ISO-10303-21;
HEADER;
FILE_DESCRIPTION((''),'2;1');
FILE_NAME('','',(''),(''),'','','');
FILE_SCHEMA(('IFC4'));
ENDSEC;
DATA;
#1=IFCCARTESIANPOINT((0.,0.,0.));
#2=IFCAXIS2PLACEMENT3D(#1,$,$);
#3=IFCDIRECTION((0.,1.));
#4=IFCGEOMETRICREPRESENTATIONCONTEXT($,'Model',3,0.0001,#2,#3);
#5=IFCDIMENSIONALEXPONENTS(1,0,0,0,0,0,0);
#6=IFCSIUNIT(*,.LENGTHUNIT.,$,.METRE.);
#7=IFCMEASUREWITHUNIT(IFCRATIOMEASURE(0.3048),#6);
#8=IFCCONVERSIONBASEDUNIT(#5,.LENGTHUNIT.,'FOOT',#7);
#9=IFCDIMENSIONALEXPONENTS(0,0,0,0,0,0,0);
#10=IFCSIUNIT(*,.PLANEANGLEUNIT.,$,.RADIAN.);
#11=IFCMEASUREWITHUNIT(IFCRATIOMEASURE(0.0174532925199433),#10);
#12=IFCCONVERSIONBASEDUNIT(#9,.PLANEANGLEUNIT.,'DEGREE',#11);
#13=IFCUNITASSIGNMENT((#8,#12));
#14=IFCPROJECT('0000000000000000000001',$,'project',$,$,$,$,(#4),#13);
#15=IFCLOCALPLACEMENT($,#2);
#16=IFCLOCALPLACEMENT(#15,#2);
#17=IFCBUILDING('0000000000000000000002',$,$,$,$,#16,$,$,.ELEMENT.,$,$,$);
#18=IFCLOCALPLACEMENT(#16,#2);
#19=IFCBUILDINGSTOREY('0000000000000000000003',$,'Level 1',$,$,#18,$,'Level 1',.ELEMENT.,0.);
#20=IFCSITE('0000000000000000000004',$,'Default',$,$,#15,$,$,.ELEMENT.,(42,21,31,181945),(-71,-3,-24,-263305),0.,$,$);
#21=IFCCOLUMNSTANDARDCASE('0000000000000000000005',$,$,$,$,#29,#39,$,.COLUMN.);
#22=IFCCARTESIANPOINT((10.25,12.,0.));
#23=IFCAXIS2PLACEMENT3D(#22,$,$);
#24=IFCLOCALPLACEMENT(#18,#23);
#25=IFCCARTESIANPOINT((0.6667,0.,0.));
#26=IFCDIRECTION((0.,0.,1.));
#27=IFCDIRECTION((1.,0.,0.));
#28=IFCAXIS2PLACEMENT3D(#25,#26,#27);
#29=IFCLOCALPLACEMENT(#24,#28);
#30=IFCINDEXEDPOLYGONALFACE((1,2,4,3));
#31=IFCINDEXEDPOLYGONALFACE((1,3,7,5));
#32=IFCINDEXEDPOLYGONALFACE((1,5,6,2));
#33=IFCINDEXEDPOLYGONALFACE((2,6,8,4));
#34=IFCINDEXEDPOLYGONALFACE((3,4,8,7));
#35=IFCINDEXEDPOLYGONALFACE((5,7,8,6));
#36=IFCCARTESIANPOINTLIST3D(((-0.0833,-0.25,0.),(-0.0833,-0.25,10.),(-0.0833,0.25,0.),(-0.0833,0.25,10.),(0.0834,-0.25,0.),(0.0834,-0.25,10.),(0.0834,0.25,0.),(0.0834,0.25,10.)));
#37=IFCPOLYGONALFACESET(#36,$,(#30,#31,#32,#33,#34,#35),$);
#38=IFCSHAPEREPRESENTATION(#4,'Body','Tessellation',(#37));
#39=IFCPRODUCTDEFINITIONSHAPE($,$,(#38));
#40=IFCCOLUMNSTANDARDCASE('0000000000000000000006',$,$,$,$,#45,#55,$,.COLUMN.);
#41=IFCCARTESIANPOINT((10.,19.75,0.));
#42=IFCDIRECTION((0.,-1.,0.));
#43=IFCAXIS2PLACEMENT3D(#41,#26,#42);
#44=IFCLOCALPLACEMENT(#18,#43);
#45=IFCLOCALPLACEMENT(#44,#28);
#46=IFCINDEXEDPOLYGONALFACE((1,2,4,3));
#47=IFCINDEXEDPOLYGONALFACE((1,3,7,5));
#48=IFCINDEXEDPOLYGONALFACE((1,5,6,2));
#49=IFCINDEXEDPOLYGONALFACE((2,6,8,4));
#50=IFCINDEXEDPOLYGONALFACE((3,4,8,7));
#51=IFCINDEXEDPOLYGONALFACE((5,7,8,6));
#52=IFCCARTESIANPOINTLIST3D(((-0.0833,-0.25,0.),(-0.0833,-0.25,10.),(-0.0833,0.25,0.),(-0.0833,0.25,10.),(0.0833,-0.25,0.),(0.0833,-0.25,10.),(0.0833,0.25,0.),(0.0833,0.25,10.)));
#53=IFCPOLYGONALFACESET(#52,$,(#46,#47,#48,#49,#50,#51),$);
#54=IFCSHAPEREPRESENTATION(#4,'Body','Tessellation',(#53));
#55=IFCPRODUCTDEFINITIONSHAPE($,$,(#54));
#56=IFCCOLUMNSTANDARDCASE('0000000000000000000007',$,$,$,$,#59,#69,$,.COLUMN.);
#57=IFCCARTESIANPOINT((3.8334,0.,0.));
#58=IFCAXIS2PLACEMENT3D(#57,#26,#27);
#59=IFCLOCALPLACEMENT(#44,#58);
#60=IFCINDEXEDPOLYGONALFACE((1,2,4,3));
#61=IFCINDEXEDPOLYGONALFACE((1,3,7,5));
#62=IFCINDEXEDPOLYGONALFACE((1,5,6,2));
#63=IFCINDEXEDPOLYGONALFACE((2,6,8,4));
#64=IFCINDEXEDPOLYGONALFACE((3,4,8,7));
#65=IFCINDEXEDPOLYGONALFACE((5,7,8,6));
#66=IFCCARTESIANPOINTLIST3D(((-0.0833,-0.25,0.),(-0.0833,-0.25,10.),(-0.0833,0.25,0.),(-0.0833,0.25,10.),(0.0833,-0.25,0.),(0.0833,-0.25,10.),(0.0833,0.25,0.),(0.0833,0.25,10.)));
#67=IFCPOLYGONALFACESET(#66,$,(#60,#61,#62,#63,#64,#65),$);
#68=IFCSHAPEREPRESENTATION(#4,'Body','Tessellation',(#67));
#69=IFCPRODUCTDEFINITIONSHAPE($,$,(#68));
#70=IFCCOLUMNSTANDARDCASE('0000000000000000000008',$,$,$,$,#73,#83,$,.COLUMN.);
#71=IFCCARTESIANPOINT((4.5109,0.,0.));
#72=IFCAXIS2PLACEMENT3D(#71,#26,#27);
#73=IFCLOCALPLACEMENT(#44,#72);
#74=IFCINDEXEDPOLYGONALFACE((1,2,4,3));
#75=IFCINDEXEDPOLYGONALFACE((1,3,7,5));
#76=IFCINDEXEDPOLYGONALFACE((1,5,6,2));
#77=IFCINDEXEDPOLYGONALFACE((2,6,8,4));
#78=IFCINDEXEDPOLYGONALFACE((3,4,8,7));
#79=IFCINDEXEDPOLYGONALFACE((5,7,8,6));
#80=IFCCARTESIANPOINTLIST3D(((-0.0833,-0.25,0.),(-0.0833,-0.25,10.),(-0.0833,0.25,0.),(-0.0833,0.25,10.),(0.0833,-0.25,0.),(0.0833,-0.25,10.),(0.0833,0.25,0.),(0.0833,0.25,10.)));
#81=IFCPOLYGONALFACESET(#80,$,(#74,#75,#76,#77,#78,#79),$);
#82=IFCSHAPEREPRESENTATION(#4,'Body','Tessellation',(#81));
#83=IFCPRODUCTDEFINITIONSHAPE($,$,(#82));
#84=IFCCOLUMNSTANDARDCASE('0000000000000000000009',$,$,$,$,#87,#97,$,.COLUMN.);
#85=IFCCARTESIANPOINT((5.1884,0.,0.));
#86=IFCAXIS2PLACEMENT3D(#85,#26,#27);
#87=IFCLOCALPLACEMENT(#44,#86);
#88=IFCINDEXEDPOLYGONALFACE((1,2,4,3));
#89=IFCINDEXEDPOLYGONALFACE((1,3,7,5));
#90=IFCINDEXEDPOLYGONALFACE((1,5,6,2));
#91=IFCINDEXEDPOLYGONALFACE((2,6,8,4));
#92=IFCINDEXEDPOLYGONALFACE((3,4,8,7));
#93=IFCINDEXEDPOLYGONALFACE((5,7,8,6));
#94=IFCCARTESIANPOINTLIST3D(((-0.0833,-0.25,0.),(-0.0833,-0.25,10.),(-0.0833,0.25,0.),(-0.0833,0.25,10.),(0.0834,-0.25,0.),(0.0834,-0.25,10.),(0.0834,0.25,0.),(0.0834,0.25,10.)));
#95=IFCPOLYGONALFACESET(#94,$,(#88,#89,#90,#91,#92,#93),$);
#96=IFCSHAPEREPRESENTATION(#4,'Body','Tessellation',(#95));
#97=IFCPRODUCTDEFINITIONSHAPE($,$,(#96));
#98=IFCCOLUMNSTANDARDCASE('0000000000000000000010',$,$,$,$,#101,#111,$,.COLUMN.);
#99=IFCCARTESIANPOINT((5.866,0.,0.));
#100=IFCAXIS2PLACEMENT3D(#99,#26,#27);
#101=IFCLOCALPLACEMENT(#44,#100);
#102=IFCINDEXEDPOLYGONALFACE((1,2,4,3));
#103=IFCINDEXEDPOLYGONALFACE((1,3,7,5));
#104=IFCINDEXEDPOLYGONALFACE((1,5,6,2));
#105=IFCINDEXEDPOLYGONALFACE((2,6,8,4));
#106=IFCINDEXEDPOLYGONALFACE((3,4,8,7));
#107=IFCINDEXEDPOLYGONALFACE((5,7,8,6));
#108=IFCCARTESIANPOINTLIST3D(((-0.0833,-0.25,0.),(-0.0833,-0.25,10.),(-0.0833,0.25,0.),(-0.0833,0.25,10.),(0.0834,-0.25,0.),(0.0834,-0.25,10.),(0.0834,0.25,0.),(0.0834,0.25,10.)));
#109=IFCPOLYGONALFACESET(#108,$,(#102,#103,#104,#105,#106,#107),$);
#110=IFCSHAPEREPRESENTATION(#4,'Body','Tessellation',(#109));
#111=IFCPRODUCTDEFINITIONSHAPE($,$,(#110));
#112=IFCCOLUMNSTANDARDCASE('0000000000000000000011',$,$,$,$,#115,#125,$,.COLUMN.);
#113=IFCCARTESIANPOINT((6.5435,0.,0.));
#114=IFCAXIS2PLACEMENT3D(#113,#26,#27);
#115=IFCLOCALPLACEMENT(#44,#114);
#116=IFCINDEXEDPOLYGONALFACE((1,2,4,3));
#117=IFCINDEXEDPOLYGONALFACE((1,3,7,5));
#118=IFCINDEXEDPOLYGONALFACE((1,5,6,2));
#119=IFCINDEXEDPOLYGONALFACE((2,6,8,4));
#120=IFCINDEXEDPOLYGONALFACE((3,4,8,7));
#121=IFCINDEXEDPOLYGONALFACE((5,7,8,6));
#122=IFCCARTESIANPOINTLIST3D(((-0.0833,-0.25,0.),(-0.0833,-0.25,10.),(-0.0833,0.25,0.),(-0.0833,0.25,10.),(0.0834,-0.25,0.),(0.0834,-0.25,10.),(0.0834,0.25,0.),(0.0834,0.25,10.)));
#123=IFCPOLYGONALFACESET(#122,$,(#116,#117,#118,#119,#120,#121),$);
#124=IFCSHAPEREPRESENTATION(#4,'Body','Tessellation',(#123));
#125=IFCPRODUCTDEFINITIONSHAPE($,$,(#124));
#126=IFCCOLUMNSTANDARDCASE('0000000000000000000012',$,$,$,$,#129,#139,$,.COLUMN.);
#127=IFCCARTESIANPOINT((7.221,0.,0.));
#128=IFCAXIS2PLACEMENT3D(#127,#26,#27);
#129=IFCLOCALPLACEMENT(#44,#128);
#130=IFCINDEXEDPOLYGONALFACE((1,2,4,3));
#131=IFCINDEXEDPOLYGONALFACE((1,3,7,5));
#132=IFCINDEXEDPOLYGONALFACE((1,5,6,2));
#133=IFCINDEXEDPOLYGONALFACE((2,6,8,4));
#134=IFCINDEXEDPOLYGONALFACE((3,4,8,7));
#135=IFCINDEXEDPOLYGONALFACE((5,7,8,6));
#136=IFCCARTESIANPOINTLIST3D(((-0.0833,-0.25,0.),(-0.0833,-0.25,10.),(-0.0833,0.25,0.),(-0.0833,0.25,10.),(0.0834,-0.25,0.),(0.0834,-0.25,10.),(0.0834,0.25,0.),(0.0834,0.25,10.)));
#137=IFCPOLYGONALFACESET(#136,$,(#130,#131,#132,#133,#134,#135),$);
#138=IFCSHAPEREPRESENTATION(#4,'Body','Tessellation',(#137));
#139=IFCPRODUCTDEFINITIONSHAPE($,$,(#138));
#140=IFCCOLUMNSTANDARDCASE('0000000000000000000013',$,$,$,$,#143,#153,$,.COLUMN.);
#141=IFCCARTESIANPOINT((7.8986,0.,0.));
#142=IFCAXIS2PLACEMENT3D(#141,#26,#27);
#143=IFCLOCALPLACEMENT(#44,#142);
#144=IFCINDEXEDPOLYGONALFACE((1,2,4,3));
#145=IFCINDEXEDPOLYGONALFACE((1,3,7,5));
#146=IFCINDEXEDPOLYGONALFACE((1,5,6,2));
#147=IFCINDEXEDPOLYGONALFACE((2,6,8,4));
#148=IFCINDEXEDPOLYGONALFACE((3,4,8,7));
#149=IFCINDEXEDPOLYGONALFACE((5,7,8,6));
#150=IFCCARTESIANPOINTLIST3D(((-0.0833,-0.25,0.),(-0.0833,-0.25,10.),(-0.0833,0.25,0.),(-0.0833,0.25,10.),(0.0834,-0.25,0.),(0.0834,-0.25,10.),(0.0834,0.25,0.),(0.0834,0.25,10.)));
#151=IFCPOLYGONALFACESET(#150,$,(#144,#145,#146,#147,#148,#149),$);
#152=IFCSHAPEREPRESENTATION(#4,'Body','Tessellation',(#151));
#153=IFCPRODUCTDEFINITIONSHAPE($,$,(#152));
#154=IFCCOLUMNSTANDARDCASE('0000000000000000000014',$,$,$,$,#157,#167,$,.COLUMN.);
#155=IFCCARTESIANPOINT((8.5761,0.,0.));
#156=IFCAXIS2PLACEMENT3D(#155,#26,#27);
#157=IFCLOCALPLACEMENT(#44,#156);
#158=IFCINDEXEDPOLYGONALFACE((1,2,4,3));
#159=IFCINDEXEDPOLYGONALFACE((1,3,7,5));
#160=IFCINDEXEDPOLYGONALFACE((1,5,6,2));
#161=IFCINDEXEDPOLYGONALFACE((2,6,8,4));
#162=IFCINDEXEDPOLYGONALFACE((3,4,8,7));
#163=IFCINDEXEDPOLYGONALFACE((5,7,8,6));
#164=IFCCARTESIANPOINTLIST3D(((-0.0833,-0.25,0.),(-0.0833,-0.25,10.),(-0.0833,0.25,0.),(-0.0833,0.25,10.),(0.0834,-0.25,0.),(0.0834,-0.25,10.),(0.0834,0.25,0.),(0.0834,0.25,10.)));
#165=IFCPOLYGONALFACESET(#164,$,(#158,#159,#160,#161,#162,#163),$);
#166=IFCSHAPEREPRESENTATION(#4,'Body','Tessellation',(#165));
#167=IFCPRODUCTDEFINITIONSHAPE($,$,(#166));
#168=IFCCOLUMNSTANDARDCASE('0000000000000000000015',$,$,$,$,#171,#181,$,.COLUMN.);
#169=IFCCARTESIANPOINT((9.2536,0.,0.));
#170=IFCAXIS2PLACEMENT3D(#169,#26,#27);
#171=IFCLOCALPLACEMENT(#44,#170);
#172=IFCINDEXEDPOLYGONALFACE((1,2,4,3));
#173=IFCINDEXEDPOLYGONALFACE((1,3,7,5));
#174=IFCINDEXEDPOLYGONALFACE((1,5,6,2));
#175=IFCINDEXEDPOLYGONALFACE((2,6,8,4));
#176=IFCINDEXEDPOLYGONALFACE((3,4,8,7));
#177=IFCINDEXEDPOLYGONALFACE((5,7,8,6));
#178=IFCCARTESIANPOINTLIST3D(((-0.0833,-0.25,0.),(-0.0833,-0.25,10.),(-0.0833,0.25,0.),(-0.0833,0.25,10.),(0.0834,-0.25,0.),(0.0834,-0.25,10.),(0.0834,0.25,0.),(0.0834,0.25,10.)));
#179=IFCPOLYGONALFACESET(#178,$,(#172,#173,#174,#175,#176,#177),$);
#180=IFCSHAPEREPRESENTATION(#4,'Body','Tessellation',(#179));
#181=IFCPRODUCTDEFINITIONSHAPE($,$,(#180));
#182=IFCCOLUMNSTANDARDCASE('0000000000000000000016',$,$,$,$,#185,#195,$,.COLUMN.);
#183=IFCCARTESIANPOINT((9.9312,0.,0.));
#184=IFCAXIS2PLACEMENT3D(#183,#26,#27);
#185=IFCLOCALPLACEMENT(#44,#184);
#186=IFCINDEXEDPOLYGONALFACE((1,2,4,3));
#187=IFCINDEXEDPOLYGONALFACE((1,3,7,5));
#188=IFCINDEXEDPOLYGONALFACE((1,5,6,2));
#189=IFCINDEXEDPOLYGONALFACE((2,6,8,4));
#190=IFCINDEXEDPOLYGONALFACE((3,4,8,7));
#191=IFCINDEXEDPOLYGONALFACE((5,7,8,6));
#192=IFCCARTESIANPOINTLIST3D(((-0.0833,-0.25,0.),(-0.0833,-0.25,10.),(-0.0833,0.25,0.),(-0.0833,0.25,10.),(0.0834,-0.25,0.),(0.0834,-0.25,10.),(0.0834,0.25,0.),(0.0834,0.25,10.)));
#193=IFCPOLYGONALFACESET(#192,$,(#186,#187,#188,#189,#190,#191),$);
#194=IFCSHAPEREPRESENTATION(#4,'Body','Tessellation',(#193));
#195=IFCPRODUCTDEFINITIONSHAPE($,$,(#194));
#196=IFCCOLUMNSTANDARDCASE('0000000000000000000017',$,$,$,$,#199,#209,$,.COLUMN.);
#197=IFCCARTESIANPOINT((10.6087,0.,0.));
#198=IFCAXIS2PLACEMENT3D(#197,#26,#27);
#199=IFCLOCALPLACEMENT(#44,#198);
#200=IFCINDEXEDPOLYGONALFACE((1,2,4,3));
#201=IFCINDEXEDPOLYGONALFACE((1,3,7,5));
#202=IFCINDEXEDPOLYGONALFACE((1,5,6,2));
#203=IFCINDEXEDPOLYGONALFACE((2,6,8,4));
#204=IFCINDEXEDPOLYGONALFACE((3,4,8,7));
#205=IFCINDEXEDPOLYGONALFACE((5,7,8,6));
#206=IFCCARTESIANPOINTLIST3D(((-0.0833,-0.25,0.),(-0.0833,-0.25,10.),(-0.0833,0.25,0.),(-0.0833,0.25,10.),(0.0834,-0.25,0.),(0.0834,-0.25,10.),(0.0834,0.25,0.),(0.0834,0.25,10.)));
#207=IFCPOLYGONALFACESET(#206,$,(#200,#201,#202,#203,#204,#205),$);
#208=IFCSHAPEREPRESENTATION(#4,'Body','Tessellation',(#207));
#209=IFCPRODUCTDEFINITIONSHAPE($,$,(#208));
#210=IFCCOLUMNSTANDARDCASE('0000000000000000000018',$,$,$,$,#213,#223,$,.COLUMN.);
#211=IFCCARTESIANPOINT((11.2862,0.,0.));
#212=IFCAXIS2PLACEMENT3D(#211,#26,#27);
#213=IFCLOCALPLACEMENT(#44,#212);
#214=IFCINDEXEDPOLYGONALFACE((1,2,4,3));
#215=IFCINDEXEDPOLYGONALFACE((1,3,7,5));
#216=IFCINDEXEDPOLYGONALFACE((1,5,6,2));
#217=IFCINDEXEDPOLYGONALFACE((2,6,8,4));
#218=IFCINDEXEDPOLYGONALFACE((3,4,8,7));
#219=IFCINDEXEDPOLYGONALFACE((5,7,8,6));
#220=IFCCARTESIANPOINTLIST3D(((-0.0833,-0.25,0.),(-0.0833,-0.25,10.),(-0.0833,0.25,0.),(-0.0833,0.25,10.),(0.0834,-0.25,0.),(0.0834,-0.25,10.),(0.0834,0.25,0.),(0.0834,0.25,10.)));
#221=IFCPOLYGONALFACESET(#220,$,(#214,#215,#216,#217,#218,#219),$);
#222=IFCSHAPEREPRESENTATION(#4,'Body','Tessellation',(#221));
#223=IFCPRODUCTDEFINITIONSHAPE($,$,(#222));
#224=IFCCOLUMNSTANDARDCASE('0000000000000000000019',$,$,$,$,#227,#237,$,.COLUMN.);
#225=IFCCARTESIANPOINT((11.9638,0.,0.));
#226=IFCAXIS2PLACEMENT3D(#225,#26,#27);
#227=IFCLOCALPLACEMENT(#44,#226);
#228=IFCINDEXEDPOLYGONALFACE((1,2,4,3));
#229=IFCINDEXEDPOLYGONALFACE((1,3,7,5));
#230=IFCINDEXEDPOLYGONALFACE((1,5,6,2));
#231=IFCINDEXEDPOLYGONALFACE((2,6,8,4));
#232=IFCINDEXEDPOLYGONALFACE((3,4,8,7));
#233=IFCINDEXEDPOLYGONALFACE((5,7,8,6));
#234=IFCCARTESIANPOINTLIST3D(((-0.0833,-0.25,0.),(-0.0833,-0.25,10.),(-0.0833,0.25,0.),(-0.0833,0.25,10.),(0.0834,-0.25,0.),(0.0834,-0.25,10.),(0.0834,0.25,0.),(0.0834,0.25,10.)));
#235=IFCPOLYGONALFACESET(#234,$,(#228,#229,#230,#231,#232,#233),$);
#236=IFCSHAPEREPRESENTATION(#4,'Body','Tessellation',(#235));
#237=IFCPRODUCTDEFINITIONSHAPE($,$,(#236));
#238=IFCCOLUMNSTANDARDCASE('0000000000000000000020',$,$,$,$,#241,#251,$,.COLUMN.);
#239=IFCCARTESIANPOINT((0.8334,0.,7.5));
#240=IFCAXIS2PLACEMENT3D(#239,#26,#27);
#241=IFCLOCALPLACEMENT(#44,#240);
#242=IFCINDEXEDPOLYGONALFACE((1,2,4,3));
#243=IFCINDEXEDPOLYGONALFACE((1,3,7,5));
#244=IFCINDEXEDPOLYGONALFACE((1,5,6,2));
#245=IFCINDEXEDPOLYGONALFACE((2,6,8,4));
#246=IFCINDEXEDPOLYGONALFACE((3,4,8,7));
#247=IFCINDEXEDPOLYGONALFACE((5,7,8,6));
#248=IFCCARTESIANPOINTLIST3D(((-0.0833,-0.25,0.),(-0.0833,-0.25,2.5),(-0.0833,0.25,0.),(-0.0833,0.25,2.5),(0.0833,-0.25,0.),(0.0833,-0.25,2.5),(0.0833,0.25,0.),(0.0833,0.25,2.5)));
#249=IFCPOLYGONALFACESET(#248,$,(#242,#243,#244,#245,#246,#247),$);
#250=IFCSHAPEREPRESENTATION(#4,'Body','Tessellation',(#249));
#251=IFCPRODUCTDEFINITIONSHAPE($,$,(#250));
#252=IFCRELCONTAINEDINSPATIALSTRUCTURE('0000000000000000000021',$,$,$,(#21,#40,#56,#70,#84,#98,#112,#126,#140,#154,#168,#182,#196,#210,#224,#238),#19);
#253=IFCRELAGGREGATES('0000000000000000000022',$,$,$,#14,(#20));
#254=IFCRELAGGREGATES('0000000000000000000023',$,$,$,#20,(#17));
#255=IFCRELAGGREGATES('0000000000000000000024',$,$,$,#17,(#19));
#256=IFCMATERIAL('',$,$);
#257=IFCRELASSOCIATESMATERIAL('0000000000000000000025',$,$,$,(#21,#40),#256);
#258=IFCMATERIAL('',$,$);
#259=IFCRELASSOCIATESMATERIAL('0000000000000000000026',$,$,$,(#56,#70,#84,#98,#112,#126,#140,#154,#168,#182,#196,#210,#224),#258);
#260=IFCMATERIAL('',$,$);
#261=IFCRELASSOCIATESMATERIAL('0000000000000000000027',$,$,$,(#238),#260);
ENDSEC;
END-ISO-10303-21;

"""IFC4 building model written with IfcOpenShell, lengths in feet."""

from ifc_helpers import new_model, entity, si_unit, converted_unit, direction, frame, origin, place, context, project, spatial, rectangle, extrude, material, element, save


model = new_model("IFC4")

# Units and contexts
model_context = context("Model", 3, precision=0.0001, world=origin(), true_north=direction((0.0, 1.0)))
ifc_project = project(units=[converted_unit("LENGTHUNIT", "FOOT", entity("IfcRatioMeasure", 0.3048), si_unit("LENGTHUNIT", "METRE"), dimensions=[1, 0, 0, 0, 0, 0, 0]), converted_unit("PLANEANGLEUNIT", "DEGREE", entity("IfcRatioMeasure", 0.0174532925199433), si_unit("PLANEANGLEUNIT", "RADIAN"), dimensions=[0, 0, 0, 0, 0, 0, 0])], contexts=[model_context])

# Site, building, storey
site_placement = place(None, origin())
site = spatial("IfcSite", under=ifc_project, at=site_placement, Name="Default", CompositionType="ELEMENT", RefLatitude=(42, 21, 31, 181945), RefLongitude=(-71, -3, -24, -263305), RefElevation=0.0)
building_placement = place(site_placement, origin())
building = spatial("IfcBuilding", under=site, at=building_placement, CompositionType="ELEMENT")
storey_placement = place(building_placement, origin())
storey = spatial("IfcBuildingStorey", under=building, at=storey_placement, Name="Level 1", LongName="Level 1", CompositionType="ELEMENT", Elevation=0.0)

# Columns
ifc_material_1 = material(Name="")
wall_1_placement = place(storey_placement, frame((10.25, 12.0, 0.0)))
for number, where, z_axis, x_axis in (
    (1, (0.6667, 0.0, 0.0), (0.0, 0.0, 1.0), (1.0, 0.0, 0.0)),
):
    element("IfcColumnStandardCase", number, at=place(wall_1_placement, frame(where, z_axis=z_axis, x_axis=x_axis)), inside=storey, material=ifc_material_1, PredefinedType="COLUMN", context=model_context, shape_type="SweptSolid", body=[
        extrude(rectangle(XDim=0.1667, YDim=0.5), origin(), (0.0, 0.0, 1.0), 10.0),
    ])
wall_2_placement = place(storey_placement, frame((10.0, 19.75, 0.0), z_axis=(0.0, 0.0, 1.0), x_axis=(0.0, -1.0, 0.0)))
for number, where, z_axis, x_axis in (
    (2, (0.6667, 0.0, 0.0), (0.0, 0.0, 1.0), (1.0, 0.0, 0.0)),
):
    element("IfcColumnStandardCase", number, at=place(wall_2_placement, frame(where, z_axis=z_axis, x_axis=x_axis)), inside=storey, material=ifc_material_1, PredefinedType="COLUMN", context=model_context, shape_type="SweptSolid", body=[
        extrude(rectangle(XDim=0.1667, YDim=0.5), origin(), (0.0, 0.0, 1.0), 10.0),
    ])
ifc_material_2 = material(Name="")
for number, where, z_axis, x_axis in (
    (3, (3.8334, 0.0, 0.0), (0.0, 0.0, 1.0), (1.0, 0.0, 0.0)),
    (4, (4.5109, 0.0, 0.0), (0.0, 0.0, 1.0), (1.0, 0.0, 0.0)),
    (5, (5.1884, 0.0, 0.0), (0.0, 0.0, 1.0), (1.0, 0.0, 0.0)),
    (6, (5.866, 0.0, 0.0), (0.0, 0.0, 1.0), (1.0, 0.0, 0.0)),
    (7, (6.5435, 0.0, 0.0), (0.0, 0.0, 1.0), (1.0, 0.0, 0.0)),
    (8, (7.221, 0.0, 0.0), (0.0, 0.0, 1.0), (1.0, 0.0, 0.0)),
    (9, (7.8986, 0.0, 0.0), (0.0, 0.0, 1.0), (1.0, 0.0, 0.0)),
    (10, (8.5761, 0.0, 0.0), (0.0, 0.0, 1.0), (1.0, 0.0, 0.0)),
    (11, (9.2536, 0.0, 0.0), (0.0, 0.0, 1.0), (1.0, 0.0, 0.0)),
    (12, (9.9312, 0.0, 0.0), (0.0, 0.0, 1.0), (1.0, 0.0, 0.0)),
    (13, (10.6087, 0.0, 0.0), (0.0, 0.0, 1.0), (1.0, 0.0, 0.0)),
    (14, (11.2862, 0.0, 0.0), (0.0, 0.0, 1.0), (1.0, 0.0, 0.0)),
    (15, (11.9638, 0.0, 0.0), (0.0, 0.0, 1.0), (1.0, 0.0, 0.0)),
):
    element("IfcColumnStandardCase", number, at=place(wall_2_placement, frame(where, z_axis=z_axis, x_axis=x_axis)), inside=storey, material=ifc_material_2, PredefinedType="COLUMN", context=model_context, shape_type="SweptSolid", body=[
        extrude(rectangle(XDim=0.1667, YDim=0.5), origin(), (0.0, 0.0, 1.0), 10.0),
    ])
ifc_material_3 = material(Name="")
for number, where, z_axis, x_axis in (
    (16, (0.8334, 0.0, 7.5), (0.0, 0.0, 1.0), (1.0, 0.0, 0.0)),
):
    element("IfcColumnStandardCase", number, at=place(wall_2_placement, frame(where, z_axis=z_axis, x_axis=x_axis)), inside=storey, material=ifc_material_3, PredefinedType="COLUMN", context=model_context, shape_type="SweptSolid", body=[
        extrude(rectangle(XDim=0.1667, YDim=0.5), origin(), (0.0, 0.0, 1.0), 2.5),
    ])

save(model, "model.ifc")
